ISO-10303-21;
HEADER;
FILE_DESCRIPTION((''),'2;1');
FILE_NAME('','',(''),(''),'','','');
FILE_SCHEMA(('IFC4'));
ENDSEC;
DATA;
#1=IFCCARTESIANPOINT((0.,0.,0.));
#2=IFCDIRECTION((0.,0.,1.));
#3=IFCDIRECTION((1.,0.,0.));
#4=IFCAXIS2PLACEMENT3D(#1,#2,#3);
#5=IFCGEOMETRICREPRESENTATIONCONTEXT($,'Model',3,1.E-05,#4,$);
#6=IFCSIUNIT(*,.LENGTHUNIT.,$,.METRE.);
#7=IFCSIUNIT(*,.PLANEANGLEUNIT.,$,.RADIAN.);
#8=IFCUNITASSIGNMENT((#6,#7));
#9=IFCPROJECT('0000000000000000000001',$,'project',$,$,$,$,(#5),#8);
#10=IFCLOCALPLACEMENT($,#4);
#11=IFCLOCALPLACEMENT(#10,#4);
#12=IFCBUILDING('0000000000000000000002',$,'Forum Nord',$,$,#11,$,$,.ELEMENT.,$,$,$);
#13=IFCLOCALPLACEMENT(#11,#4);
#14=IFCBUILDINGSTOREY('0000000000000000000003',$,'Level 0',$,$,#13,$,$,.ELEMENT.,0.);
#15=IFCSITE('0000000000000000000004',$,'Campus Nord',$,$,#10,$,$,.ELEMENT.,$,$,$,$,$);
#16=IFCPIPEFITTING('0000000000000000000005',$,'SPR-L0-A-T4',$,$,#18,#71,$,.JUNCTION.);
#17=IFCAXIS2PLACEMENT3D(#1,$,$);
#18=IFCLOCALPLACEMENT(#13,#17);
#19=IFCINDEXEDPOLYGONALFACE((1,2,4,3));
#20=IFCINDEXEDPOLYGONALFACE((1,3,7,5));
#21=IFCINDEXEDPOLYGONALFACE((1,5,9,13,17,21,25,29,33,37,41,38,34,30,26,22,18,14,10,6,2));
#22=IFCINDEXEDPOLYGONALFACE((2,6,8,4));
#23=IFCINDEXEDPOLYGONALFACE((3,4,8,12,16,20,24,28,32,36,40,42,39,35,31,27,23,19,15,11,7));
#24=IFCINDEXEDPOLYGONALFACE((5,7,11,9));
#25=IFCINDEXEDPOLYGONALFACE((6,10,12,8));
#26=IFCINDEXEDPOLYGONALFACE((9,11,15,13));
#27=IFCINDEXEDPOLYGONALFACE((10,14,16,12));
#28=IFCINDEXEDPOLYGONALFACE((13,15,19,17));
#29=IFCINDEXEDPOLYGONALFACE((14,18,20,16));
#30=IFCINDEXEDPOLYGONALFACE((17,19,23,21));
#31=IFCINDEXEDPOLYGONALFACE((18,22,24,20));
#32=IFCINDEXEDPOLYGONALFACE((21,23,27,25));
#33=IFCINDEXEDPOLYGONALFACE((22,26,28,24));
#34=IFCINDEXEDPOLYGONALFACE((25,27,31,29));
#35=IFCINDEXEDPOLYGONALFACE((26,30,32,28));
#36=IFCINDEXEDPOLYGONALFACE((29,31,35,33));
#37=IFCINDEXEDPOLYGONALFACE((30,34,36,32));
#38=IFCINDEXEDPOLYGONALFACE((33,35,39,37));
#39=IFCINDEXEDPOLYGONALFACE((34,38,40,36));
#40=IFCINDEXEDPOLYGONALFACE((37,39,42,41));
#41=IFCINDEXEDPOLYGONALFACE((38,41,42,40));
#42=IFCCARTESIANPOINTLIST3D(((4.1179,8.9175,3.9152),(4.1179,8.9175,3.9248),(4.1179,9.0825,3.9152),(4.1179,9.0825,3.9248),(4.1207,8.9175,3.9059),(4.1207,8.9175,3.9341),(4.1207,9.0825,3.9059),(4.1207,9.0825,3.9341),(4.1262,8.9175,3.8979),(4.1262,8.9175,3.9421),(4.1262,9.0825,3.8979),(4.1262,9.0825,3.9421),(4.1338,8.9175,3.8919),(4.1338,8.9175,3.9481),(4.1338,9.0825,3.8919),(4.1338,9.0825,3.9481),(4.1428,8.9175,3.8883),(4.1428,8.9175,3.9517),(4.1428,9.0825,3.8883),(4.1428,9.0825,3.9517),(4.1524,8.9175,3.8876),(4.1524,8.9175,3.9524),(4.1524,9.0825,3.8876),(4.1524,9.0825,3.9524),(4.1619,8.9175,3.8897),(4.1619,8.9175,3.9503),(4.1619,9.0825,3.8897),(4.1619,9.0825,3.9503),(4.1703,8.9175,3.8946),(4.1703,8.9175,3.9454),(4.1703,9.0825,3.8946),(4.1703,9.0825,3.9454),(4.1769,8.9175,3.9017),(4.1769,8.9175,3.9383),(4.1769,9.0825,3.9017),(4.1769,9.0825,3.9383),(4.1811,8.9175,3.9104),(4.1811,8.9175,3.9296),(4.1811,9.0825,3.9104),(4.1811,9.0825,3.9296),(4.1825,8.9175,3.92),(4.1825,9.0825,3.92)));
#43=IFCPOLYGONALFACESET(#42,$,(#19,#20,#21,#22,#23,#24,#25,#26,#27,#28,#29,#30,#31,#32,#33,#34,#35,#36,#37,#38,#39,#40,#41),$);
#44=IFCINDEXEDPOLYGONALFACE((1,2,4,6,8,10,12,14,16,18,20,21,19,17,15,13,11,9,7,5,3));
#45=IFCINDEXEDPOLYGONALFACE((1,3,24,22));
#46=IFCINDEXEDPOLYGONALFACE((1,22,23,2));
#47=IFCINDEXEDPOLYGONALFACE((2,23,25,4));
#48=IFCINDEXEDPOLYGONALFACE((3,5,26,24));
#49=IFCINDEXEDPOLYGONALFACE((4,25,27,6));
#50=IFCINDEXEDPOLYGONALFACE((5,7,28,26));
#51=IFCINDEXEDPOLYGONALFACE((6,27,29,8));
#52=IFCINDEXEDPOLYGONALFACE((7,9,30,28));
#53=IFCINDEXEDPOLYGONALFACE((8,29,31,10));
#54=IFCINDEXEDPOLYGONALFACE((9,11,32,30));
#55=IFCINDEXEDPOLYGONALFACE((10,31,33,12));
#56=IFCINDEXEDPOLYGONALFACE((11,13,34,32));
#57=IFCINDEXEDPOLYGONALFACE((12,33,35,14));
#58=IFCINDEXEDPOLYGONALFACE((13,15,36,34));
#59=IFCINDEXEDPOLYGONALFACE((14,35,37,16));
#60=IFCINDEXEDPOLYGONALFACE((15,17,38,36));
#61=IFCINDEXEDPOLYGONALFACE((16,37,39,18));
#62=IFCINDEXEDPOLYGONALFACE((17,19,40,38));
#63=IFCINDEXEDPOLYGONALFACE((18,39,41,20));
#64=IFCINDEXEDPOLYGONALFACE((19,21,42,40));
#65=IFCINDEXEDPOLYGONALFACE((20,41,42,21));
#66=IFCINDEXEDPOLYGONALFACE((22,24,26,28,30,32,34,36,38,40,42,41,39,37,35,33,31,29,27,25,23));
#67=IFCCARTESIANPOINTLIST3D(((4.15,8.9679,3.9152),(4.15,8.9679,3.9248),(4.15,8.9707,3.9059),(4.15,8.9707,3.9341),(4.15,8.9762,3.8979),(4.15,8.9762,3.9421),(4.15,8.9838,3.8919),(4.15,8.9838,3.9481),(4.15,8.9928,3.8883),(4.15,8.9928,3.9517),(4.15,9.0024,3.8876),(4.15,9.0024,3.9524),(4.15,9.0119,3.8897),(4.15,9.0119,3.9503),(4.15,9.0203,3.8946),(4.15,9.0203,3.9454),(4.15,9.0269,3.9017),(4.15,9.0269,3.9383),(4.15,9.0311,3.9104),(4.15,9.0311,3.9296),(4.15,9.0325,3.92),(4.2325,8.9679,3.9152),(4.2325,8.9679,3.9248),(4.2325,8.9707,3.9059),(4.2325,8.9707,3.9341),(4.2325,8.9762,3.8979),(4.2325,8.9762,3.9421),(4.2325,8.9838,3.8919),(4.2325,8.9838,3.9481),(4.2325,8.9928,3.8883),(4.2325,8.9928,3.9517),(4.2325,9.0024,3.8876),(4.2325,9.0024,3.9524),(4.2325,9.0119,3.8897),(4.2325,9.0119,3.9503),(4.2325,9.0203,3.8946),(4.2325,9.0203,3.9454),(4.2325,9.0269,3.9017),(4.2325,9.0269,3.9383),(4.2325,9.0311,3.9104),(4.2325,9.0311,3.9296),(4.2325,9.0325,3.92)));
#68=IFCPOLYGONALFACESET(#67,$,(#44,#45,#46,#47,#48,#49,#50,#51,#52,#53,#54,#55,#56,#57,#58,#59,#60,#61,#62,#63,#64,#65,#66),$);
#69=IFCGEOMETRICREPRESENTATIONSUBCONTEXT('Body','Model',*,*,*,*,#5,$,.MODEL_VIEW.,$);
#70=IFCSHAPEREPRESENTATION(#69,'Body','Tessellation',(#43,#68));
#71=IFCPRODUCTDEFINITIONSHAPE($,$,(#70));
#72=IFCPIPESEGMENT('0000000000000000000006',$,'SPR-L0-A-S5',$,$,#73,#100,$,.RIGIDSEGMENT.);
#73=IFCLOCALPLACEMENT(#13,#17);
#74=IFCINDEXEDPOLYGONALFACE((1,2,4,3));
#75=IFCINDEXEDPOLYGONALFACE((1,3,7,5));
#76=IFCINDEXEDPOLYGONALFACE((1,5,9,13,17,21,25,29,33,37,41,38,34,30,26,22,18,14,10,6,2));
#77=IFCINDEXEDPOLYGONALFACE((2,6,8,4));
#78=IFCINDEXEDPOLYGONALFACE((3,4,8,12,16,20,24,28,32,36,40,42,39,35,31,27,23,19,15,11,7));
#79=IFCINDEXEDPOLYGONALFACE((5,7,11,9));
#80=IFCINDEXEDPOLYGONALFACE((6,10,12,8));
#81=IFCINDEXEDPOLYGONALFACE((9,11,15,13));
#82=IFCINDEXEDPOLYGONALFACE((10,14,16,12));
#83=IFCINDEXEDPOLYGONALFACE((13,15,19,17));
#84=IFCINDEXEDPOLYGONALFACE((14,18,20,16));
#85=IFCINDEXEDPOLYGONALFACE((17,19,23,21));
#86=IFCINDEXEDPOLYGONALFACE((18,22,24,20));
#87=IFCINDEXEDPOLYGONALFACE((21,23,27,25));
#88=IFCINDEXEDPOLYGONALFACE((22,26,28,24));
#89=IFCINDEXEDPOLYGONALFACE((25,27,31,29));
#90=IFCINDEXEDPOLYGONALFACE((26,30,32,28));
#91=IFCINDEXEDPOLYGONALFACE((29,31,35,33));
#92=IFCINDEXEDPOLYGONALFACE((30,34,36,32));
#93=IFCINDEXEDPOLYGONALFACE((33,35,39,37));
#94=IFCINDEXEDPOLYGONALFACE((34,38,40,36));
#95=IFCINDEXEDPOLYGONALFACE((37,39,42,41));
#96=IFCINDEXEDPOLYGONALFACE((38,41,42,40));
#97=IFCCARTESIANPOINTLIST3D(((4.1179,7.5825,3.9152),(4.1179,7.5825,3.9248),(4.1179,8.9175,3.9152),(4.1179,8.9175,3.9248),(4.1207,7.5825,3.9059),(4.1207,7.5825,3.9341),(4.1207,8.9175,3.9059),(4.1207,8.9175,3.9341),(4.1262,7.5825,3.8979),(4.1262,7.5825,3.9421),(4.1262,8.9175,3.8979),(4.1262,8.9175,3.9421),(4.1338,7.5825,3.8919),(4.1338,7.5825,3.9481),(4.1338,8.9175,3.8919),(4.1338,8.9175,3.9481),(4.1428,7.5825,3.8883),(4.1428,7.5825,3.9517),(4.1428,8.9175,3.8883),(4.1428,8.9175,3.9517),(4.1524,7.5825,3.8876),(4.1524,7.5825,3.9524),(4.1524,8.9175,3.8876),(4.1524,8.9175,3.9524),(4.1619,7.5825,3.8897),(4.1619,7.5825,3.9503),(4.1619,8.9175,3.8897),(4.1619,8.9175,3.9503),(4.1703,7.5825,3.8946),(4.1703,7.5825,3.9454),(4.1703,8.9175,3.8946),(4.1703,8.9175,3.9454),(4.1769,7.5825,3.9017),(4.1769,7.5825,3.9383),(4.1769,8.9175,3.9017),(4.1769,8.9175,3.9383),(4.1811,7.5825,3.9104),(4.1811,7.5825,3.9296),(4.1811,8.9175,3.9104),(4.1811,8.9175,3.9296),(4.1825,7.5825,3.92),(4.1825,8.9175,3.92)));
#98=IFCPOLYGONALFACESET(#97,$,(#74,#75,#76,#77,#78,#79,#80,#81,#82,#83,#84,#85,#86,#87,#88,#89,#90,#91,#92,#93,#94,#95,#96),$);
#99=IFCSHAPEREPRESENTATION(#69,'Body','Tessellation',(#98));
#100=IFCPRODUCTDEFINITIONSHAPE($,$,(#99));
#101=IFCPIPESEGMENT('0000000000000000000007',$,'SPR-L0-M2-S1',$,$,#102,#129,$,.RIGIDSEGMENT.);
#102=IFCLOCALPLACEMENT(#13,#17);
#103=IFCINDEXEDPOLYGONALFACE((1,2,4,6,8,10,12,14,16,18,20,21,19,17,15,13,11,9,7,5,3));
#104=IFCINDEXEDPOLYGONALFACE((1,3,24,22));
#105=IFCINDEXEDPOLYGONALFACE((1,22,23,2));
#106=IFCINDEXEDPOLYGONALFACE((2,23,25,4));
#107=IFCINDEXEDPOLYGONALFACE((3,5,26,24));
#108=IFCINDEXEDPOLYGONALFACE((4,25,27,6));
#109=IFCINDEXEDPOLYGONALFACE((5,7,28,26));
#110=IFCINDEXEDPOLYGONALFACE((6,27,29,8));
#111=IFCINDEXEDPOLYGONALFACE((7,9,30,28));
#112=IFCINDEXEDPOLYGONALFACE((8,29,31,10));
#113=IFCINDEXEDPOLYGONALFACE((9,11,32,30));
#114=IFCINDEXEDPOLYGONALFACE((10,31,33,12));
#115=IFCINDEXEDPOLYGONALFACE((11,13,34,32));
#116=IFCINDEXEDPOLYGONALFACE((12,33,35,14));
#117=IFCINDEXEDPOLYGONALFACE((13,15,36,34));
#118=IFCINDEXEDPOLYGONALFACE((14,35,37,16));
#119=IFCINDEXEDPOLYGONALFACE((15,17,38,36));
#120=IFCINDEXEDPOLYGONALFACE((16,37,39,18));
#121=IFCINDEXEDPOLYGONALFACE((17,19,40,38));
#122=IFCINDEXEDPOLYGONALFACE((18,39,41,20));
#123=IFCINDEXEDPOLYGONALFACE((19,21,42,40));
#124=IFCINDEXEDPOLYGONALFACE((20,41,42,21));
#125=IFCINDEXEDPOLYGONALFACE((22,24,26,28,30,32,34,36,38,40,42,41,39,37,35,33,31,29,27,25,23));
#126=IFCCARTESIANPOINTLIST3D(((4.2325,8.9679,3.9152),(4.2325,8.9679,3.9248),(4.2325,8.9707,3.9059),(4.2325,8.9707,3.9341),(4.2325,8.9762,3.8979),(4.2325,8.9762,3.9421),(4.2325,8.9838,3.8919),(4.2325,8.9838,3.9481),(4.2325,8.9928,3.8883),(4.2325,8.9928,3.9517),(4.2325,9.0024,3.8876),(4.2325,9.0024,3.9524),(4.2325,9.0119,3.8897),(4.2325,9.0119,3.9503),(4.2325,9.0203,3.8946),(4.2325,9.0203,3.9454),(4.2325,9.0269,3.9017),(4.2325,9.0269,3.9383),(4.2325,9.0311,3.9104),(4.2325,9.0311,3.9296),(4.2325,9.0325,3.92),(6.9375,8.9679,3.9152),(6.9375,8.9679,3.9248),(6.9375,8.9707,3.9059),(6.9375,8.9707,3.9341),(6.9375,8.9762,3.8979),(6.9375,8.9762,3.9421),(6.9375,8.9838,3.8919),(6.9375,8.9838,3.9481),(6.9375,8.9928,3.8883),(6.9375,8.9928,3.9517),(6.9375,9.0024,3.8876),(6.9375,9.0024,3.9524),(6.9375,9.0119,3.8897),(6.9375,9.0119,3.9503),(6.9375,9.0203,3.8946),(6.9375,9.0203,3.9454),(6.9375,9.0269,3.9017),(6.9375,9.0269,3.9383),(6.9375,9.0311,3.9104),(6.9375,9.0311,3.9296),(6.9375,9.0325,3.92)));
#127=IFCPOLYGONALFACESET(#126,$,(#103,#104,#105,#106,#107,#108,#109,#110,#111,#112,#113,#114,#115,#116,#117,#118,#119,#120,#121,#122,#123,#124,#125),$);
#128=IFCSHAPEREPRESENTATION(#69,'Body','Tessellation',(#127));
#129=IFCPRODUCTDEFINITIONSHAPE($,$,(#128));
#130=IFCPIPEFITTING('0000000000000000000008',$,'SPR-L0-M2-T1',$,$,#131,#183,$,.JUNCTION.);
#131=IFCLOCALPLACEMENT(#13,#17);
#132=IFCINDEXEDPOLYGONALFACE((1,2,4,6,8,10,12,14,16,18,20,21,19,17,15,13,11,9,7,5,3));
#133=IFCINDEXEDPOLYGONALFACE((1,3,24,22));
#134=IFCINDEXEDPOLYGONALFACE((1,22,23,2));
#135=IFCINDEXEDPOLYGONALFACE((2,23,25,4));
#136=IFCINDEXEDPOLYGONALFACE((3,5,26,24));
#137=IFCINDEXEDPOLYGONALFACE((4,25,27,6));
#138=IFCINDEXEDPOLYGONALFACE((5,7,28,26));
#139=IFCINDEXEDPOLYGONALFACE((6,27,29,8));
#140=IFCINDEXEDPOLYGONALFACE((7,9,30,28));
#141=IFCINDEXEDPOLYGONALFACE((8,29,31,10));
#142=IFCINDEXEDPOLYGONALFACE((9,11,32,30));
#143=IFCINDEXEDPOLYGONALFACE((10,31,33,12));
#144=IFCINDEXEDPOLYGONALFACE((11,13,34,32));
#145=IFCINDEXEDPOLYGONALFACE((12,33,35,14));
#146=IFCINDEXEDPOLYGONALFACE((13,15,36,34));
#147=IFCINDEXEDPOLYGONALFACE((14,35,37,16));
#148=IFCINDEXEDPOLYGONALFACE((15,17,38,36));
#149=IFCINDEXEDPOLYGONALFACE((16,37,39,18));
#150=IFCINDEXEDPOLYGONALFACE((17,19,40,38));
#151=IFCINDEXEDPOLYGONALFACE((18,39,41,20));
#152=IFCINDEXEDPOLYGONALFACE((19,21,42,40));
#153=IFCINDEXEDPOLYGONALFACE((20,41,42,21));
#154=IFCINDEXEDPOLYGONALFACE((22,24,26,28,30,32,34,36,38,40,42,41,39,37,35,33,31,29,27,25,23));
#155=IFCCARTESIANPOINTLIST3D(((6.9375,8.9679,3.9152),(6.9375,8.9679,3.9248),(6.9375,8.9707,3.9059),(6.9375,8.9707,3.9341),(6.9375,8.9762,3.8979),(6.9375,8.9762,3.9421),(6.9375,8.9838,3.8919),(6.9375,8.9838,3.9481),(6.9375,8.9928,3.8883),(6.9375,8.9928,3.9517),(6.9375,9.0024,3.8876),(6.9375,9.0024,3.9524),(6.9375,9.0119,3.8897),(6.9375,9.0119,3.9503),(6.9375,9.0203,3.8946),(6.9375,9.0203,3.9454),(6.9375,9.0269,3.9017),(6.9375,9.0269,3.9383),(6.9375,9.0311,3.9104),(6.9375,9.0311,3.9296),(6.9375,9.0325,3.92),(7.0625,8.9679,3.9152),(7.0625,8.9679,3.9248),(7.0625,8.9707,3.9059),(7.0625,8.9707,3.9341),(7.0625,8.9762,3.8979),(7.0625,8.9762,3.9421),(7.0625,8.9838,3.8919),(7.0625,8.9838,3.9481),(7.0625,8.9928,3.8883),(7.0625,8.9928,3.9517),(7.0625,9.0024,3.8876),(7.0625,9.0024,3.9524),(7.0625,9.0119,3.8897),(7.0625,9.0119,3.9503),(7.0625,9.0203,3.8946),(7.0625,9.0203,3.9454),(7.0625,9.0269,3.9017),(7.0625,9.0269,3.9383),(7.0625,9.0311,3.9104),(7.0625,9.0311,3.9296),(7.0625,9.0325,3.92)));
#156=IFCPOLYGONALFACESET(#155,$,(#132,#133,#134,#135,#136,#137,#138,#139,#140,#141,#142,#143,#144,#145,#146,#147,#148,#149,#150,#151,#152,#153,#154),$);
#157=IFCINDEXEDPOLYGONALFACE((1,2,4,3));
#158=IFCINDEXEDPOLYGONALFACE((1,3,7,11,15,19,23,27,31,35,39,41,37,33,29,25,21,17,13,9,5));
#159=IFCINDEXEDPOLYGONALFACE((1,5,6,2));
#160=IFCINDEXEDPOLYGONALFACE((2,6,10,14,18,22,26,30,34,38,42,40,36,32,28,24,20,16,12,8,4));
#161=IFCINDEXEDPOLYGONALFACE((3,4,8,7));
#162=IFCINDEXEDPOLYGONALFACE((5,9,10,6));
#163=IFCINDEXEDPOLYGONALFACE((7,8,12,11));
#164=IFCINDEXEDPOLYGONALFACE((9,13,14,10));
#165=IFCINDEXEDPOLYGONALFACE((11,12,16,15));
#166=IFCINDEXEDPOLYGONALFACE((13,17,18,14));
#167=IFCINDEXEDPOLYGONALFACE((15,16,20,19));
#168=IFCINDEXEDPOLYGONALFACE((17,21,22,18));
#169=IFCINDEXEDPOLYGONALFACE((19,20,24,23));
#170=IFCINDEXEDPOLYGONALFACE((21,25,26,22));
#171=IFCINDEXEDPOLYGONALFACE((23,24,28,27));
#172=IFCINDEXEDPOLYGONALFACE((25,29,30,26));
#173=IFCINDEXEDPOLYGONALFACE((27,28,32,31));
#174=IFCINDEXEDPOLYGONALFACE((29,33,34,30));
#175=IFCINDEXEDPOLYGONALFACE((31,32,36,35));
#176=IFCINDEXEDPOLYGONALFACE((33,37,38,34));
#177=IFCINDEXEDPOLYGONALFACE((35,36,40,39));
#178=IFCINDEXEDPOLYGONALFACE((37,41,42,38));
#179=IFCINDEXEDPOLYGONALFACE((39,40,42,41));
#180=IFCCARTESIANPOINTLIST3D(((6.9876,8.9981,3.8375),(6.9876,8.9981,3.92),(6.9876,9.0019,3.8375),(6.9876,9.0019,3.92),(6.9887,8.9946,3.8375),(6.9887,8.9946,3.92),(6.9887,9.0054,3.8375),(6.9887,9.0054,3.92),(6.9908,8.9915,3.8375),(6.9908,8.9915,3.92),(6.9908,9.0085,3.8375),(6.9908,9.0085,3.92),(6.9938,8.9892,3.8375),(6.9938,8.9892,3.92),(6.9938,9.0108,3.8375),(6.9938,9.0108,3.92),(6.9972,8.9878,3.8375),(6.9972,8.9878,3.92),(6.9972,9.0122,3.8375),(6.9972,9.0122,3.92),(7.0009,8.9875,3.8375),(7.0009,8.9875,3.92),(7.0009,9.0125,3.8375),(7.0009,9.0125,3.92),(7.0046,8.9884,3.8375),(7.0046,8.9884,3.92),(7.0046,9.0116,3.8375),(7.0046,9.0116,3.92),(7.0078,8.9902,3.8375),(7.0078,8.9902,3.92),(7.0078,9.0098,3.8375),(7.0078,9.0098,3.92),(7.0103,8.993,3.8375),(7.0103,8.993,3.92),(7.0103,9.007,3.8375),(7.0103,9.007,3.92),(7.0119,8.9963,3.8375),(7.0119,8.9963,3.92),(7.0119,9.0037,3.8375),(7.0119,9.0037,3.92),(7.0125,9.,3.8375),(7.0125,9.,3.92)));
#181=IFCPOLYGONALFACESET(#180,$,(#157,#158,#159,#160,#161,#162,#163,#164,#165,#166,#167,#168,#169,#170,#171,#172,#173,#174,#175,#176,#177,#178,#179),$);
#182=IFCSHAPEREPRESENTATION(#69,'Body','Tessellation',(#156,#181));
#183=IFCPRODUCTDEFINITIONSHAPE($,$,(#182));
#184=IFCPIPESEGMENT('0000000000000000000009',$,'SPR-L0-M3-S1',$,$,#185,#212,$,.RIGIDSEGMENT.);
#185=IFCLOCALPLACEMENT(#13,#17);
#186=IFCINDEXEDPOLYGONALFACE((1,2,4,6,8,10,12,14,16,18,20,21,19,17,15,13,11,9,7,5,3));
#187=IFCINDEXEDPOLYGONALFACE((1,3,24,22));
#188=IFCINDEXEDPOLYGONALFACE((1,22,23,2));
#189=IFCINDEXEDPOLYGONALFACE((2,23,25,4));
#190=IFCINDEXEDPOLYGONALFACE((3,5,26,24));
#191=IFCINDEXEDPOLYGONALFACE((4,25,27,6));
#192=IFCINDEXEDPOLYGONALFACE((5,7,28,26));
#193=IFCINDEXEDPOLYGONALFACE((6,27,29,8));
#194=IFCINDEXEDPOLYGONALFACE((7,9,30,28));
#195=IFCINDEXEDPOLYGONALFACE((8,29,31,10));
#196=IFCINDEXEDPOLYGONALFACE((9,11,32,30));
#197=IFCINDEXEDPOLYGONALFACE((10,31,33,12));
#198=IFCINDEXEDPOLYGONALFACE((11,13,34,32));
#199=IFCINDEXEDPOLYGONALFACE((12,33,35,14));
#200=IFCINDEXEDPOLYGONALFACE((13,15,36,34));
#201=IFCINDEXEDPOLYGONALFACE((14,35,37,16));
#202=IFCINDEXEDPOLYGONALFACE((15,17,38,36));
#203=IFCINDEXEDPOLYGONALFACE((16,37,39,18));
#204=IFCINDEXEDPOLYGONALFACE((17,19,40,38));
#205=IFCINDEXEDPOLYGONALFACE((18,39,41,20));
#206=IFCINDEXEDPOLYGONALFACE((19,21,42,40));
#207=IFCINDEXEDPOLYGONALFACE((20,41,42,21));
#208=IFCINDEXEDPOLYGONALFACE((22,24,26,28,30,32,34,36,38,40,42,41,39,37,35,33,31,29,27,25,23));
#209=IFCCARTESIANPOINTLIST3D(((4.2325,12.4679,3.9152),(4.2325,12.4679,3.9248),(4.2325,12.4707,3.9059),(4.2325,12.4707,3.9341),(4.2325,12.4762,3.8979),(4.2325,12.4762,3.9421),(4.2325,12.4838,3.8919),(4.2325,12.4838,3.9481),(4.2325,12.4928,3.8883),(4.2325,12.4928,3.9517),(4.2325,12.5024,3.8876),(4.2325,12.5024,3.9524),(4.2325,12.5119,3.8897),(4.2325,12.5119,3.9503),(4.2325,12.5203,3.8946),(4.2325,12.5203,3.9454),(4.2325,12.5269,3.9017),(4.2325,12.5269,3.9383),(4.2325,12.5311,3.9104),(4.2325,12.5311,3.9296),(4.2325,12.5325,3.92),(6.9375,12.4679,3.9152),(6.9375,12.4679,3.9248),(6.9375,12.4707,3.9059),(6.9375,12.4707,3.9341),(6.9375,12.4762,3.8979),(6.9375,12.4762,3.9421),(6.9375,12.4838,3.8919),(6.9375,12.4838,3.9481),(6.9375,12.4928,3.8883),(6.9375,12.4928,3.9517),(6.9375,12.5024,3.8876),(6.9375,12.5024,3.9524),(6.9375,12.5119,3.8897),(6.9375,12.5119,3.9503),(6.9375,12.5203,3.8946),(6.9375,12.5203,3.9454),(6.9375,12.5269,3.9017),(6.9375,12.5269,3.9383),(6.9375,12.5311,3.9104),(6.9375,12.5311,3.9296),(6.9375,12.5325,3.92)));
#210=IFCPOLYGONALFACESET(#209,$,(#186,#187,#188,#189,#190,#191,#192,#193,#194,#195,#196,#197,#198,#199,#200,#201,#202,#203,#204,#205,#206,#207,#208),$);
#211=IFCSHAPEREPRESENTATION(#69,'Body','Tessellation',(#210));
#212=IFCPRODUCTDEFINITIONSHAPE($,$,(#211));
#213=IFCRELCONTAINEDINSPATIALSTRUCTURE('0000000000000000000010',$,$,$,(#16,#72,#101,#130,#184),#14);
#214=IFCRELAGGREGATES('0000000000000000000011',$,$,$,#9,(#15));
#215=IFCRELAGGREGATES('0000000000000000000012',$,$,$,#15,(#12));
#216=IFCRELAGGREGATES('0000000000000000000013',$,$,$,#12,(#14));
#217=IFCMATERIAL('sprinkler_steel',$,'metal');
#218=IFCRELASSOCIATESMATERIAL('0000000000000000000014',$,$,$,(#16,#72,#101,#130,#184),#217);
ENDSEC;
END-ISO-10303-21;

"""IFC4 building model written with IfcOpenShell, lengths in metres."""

from ifc_helpers import new_model, si_unit, frame, origin_with_axes, origin_2d_with_axis, place, context, subcontext, project, spatial, circle, extrude, material, element, save


model = new_model("IFC4")

# Units and contexts
model_context = context("Model", 3, precision=1e-05, world=origin_with_axes())
body_context = subcontext(model_context, "Body", "Model", "MODEL_VIEW")
ifc_project = project(units=[si_unit("LENGTHUNIT", "METRE"), si_unit("PLANEANGLEUNIT", "RADIAN")], contexts=[model_context])

# Site, building, storey
site_placement = place(None, origin_with_axes())
site = spatial("IfcSite", under=ifc_project, at=site_placement, Name="Campus Nord", CompositionType="ELEMENT")
building_placement = place(site_placement, origin_with_axes())
building = spatial("IfcBuilding", under=site, at=building_placement, Name="Forum Nord", CompositionType="ELEMENT")
storey_placement = place(building_placement, origin_with_axes())
storey = spatial("IfcBuildingStorey", under=building, at=storey_placement, Name="Level 0", CompositionType="ELEMENT", Elevation=0.0)

# Shared definitions
ifc_material_1 = material(Name="sprinkler_steel", Category="metal")

# Pipe fitting
pipe_fitting_1_placement = place(storey_placement, frame((4.15, 9.0825, 3.92), z_axis=(0.0, -1.0, 0.0), x_axis=(1.0, 0.0, 0.0)))
element("IfcPipeFitting", 1, at=pipe_fitting_1_placement, inside=storey, material=ifc_material_1, Name="SPR-L0-A-T4", PredefinedType="JUNCTION", context=body_context, shape_type="SweptSolid", body=[
    extrude(circle(Radius=0.0325, at=origin_2d_with_axis()), origin_with_axes(), (0.0, 0.0, 1.0), 0.165),
    extrude(circle(Radius=0.0325, at=origin_2d_with_axis()), frame((0.0, 0.0, 0.0825), z_axis=(1.0, 0.0, 0.0), x_axis=(0.0, 0.0, -1.0)), (0.0, 0.0, 1.0), 0.0825),
])

# Pipe segments
pipe_segment_1_placement = place(storey_placement, frame((4.15, 8.9175, 3.92), z_axis=(0.0, -1.0, 0.0), x_axis=(1.0, 0.0, 0.0)))
element("IfcPipeSegment", 2, at=pipe_segment_1_placement, inside=storey, material=ifc_material_1, Name="SPR-L0-A-S5", PredefinedType="RIGIDSEGMENT", context=body_context, shape_type="SweptSolid", body=[
    extrude(circle(Radius=0.0325, at=origin_2d_with_axis()), origin_with_axes(), (0.0, 0.0, 1.0), 1.335),
])
pipe_segment_2_placement = place(storey_placement, frame((4.2325, 9.0, 3.92), z_axis=(1.0, 0.0, 0.0), x_axis=(0.0, 1.0, 0.0)))
element("IfcPipeSegment", 3, at=pipe_segment_2_placement, inside=storey, material=ifc_material_1, Name="SPR-L0-M2-S1", PredefinedType="RIGIDSEGMENT", context=body_context, shape_type="SweptSolid", body=[
    extrude(circle(Radius=0.0325, at=origin_2d_with_axis()), origin_with_axes(), (0.0, 0.0, 1.0), 2.705),
])

# Pipe fitting
pipe_fitting_2_placement = place(storey_placement, frame((6.9375, 9.0, 3.92), z_axis=(1.0, 0.0, 0.0), x_axis=(0.0, 1.0, 0.0)))
element("IfcPipeFitting", 4, at=pipe_fitting_2_placement, inside=storey, material=ifc_material_1, Name="SPR-L0-M2-T1", PredefinedType="JUNCTION", context=body_context, shape_type="SweptSolid", body=[
    extrude(circle(Radius=0.0325, at=origin_2d_with_axis()), origin_with_axes(), (0.0, 0.0, 1.0), 0.125),
    extrude(circle(Radius=0.0125, at=origin_2d_with_axis()), frame((0.0, 0.0, 0.0625), z_axis=(0.0, -1.0, 0.0), x_axis=(0.0, 0.0, 1.0)), (0.0, 0.0, 1.0), 0.0825),
])

# Pipe segment
pipe_segment_3_placement = place(storey_placement, frame((4.2325, 12.5, 3.92), z_axis=(1.0, 0.0, 0.0), x_axis=(0.0, 1.0, 0.0)))
element("IfcPipeSegment", 5, at=pipe_segment_3_placement, inside=storey, material=ifc_material_1, Name="SPR-L0-M3-S1", PredefinedType="RIGIDSEGMENT", context=body_context, shape_type="SweptSolid", body=[
    extrude(circle(Radius=0.0325, at=origin_2d_with_axis()), origin_with_axes(), (0.0, 0.0, 1.0), 2.705),
])

save(model, "model.ifc")
